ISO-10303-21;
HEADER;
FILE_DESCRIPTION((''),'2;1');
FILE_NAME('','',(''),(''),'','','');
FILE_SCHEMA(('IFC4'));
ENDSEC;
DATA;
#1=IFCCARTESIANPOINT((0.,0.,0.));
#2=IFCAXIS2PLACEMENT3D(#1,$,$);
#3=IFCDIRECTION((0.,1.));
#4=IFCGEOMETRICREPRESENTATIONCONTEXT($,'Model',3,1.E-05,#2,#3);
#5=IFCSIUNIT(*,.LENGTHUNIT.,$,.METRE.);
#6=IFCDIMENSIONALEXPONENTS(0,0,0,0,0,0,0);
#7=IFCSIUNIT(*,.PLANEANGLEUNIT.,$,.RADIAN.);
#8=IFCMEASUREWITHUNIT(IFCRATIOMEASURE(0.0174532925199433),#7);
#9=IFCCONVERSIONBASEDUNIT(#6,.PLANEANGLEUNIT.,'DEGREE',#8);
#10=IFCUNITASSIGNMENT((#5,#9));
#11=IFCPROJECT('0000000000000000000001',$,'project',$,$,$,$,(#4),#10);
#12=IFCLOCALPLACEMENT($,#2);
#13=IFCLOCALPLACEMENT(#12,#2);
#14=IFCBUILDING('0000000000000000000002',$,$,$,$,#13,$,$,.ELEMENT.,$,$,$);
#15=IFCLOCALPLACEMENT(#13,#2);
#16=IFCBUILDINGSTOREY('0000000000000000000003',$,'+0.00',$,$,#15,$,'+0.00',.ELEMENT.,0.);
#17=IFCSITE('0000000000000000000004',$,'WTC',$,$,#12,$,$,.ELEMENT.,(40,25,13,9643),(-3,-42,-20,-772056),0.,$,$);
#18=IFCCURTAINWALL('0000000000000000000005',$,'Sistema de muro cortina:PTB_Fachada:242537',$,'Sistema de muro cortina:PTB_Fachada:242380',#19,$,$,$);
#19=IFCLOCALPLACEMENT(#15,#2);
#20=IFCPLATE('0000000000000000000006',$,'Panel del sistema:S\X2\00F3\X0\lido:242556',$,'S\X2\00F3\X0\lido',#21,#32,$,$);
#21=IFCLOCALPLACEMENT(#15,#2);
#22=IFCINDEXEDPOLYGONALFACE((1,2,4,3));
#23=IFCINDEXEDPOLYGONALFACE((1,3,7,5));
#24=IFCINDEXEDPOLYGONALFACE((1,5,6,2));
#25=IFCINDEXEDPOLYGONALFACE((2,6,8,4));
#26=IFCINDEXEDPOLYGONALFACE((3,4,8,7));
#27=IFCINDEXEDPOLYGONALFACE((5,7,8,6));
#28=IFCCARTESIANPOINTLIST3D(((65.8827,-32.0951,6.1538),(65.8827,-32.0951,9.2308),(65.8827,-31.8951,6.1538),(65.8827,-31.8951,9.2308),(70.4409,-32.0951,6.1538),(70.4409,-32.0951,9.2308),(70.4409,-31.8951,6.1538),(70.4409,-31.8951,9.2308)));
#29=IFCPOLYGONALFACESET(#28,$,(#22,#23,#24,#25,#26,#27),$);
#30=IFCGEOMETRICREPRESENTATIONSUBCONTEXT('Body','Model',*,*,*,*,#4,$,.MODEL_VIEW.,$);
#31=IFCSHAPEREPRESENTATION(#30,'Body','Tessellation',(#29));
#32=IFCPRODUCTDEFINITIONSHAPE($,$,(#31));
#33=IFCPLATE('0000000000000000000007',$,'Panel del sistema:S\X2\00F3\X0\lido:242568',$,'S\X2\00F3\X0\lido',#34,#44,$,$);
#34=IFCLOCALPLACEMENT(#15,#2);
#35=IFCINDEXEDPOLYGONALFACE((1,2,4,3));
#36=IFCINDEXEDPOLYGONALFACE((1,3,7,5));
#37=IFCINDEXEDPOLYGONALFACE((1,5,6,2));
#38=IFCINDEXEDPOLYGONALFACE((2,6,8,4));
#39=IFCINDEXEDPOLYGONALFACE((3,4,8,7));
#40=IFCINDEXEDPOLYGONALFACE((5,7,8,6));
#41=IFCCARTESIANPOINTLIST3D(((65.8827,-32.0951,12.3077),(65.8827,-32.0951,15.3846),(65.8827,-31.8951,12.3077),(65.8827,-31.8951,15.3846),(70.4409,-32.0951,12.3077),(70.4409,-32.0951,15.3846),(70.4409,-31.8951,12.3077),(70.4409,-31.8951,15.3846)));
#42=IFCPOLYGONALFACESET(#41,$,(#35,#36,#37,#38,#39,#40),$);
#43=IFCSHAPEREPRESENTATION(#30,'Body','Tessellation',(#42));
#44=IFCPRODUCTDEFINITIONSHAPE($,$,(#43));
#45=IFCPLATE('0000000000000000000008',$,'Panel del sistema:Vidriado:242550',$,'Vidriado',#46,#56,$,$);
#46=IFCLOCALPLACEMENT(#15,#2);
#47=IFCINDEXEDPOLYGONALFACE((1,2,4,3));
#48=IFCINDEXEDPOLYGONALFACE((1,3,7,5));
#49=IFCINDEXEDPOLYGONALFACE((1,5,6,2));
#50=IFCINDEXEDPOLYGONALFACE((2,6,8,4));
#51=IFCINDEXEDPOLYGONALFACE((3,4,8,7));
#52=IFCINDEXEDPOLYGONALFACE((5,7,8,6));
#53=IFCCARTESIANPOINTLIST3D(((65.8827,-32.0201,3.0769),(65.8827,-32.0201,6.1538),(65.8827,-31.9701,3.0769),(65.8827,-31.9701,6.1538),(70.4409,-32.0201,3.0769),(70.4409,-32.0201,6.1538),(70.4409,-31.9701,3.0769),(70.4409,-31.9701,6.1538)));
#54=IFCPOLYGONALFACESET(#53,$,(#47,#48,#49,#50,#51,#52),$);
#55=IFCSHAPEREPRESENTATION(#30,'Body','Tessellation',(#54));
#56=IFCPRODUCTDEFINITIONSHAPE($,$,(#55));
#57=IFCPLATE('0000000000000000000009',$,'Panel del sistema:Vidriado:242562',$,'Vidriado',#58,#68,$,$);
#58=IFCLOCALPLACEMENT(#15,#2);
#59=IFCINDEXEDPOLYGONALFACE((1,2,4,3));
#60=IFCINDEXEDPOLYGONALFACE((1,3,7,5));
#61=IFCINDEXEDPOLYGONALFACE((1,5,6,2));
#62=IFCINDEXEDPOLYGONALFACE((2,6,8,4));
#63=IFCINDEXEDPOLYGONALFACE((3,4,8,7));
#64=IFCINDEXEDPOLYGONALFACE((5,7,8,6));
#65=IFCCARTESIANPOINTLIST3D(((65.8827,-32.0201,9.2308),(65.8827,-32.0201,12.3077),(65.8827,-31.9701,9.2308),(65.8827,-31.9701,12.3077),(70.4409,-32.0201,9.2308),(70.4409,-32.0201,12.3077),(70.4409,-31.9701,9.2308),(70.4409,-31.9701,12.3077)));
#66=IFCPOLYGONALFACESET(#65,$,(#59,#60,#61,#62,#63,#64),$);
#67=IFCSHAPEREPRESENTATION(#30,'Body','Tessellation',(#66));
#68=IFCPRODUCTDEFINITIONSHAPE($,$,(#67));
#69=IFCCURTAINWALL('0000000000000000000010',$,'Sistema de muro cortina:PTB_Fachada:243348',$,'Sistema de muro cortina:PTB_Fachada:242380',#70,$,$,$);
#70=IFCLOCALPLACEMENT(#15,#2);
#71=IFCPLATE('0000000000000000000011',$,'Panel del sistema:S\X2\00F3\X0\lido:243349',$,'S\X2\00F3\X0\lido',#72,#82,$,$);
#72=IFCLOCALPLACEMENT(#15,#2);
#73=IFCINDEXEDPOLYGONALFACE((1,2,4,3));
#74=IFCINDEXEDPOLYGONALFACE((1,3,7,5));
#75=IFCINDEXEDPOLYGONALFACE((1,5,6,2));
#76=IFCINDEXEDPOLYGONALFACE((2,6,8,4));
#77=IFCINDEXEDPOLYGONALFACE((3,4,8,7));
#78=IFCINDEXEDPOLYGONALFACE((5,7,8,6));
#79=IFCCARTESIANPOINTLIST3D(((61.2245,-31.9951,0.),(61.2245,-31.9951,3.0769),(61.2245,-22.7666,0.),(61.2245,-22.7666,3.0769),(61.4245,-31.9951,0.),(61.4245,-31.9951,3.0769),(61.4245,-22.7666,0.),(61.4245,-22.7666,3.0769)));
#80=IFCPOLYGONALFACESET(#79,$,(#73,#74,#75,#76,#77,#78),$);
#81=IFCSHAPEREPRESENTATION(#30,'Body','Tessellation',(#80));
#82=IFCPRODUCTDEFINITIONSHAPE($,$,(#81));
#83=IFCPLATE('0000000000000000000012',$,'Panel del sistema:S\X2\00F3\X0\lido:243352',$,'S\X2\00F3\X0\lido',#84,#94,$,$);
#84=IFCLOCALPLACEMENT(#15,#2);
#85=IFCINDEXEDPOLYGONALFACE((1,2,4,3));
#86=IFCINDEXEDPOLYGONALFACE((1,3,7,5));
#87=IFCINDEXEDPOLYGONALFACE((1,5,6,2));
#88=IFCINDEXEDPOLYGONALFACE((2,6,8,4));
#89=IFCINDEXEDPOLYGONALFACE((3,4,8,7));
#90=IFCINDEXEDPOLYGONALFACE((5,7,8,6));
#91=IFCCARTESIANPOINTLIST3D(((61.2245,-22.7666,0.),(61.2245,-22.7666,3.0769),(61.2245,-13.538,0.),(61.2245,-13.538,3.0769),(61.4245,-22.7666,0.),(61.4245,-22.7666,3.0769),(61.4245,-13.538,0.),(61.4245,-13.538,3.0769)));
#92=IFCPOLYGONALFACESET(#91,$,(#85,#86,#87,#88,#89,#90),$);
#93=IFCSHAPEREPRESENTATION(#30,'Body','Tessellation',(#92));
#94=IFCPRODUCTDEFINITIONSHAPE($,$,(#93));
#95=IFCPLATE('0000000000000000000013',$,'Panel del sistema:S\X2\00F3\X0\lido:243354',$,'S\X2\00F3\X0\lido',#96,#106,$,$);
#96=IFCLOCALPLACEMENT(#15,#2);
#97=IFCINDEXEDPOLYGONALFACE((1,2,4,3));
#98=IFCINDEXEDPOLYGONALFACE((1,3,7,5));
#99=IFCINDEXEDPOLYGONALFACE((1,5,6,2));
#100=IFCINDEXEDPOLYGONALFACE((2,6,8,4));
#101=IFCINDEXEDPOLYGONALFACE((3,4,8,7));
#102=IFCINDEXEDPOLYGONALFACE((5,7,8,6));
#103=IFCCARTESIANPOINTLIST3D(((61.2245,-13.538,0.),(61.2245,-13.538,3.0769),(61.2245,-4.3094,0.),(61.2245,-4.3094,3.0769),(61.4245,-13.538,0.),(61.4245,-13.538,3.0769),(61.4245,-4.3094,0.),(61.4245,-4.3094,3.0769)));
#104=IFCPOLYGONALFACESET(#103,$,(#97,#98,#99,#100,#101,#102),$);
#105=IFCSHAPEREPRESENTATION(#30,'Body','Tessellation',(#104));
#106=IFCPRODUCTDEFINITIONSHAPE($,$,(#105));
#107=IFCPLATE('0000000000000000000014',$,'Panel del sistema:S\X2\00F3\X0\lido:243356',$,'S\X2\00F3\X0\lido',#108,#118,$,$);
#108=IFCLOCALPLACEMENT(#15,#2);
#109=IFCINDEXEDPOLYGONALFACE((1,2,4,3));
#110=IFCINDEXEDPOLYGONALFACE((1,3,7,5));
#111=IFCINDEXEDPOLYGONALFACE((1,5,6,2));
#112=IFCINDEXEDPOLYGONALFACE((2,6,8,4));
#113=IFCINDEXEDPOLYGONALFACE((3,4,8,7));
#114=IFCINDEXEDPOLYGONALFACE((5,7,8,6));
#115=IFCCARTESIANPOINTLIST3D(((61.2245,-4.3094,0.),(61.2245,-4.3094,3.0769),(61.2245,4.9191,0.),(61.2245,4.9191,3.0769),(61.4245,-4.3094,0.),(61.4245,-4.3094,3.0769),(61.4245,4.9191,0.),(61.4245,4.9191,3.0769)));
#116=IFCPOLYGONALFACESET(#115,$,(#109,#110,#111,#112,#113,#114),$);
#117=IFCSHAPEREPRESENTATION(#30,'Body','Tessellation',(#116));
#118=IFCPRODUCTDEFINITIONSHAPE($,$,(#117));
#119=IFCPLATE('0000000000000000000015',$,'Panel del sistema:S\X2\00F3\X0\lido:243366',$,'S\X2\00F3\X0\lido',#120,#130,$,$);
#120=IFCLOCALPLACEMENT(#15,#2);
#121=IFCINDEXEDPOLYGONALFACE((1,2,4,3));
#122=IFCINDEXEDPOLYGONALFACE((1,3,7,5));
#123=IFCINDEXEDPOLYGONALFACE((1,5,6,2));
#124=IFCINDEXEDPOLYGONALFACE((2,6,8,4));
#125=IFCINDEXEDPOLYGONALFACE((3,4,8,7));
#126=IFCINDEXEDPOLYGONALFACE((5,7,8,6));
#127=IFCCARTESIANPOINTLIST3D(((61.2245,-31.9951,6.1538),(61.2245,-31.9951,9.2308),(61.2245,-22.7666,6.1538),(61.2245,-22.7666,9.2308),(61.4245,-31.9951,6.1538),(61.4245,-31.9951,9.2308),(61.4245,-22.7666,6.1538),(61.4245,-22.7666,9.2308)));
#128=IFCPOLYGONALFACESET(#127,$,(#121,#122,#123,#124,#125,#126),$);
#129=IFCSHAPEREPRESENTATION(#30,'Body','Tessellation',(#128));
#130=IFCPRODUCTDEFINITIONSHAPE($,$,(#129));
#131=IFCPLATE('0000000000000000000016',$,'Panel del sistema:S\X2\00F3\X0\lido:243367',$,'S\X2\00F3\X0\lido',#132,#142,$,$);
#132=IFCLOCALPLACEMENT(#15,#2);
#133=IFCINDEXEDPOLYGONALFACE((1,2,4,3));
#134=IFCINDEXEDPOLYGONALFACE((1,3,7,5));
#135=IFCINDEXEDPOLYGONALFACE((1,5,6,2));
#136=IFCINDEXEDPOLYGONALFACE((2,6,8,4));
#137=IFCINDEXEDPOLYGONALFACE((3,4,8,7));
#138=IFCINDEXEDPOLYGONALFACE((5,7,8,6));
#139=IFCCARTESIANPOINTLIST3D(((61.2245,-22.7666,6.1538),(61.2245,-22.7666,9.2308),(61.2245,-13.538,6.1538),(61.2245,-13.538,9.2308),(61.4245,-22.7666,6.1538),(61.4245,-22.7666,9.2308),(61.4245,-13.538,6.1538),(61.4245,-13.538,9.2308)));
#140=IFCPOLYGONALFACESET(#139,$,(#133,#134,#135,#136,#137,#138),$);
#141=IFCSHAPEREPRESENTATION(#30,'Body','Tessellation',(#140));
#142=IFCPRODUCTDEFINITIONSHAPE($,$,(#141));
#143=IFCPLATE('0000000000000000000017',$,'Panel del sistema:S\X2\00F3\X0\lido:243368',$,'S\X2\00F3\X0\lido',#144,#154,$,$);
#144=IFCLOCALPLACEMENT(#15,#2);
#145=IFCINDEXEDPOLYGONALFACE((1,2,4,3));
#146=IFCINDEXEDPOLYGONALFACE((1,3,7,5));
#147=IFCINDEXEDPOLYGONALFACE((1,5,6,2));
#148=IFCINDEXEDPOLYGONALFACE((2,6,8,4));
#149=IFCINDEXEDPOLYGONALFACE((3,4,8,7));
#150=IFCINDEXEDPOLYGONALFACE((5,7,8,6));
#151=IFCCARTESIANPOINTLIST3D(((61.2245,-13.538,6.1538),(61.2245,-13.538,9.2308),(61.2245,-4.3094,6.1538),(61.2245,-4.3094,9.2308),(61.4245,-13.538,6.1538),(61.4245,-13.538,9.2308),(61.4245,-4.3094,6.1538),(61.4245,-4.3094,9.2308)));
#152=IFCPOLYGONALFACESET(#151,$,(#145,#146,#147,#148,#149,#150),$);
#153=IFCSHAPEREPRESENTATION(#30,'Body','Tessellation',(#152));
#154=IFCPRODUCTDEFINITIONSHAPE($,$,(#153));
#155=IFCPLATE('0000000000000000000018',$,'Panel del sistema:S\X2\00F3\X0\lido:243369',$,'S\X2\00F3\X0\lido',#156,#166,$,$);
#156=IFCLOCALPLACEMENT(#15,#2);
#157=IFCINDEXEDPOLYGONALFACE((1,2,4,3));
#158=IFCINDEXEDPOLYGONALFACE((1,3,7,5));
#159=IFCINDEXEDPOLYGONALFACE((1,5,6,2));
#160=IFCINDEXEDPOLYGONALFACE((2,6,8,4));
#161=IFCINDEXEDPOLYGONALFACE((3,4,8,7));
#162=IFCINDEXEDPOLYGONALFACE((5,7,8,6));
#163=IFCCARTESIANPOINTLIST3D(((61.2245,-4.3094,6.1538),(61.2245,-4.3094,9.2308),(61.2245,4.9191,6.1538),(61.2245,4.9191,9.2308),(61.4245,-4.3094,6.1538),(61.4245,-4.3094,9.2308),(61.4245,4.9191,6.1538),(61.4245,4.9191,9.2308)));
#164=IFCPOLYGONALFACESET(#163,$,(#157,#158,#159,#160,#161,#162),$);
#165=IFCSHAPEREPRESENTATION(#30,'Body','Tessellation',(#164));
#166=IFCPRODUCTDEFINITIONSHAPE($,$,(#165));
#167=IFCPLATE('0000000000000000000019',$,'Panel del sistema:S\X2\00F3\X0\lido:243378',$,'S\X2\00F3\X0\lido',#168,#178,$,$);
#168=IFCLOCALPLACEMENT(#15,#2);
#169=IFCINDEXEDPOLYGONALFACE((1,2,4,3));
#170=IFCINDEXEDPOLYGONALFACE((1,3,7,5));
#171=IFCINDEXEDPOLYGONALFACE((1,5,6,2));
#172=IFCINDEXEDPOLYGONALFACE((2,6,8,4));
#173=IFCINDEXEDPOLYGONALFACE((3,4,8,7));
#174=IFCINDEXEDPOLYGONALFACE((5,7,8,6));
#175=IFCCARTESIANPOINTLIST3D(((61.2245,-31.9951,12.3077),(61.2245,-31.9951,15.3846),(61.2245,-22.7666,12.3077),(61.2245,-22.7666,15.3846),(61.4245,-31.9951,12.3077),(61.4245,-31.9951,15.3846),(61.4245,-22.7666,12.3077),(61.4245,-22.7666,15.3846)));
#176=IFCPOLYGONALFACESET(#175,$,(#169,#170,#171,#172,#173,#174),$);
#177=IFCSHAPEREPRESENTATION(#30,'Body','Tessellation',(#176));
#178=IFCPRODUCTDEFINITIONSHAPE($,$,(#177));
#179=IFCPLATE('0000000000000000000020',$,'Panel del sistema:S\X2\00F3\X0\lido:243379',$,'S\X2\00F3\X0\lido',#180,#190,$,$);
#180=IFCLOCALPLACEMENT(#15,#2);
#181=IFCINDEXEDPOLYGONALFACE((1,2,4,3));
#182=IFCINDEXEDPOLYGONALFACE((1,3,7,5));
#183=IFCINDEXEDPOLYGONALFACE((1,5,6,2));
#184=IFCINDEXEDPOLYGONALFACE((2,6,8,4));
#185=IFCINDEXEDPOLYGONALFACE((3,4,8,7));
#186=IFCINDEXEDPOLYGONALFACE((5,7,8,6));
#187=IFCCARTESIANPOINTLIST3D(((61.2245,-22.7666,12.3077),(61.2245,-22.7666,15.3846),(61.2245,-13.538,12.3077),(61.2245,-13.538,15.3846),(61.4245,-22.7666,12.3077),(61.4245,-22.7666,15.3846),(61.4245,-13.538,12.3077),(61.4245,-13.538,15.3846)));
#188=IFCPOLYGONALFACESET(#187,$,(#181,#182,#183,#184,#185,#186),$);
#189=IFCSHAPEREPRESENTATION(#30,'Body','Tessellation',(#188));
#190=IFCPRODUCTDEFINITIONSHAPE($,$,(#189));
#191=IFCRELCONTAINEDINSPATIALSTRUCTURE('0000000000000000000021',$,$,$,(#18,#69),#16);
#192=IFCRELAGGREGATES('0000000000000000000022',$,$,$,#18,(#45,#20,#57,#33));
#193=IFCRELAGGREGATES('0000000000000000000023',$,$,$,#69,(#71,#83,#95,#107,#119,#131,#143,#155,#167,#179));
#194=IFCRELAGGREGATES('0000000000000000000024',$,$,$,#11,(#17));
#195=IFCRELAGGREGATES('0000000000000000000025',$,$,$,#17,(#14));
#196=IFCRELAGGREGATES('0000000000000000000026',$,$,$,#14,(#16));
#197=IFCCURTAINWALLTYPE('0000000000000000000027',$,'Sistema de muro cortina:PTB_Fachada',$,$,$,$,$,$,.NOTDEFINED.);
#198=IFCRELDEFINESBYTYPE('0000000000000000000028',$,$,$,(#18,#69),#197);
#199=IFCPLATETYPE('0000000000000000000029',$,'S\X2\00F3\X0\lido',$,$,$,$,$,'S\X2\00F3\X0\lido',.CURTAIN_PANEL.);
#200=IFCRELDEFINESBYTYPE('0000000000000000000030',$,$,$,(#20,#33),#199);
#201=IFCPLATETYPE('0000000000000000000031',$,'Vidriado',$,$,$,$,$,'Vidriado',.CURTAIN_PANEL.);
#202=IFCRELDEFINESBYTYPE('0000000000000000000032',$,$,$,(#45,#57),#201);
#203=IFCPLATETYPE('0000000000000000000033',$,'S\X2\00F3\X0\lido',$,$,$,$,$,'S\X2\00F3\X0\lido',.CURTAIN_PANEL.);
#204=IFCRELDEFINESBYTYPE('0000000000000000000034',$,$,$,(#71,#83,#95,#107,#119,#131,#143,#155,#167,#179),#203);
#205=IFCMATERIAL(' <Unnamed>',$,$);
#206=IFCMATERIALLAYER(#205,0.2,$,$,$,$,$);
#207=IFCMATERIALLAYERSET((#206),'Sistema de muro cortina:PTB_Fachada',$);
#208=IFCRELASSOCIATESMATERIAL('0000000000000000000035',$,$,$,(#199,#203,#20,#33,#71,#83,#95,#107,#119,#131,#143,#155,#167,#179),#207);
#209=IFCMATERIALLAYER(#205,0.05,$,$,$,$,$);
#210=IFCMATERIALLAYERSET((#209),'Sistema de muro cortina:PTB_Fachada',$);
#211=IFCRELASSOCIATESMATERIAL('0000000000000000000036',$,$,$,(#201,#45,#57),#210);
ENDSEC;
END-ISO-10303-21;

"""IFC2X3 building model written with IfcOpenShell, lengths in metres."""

from ifc_helpers import new_model, entity, si_unit, converted_unit, direction, frame, frame_2d, origin, origin_2d_with_axis, place, context, subcontext, project, spatial, rectangle, extrude, source, transform, mapped, material, layer, layer_set, layer_usage, type_object, type_shapes, element, aggregate, save


model = new_model("IFC2X3")

# Units and contexts
model_context = context("Model", 3, precision=1e-05, world=origin(), true_north=direction((0.0, 1.0)))
body_context = subcontext(model_context, "Body", "Model", "MODEL_VIEW")
ifc_project = project(units=[si_unit("LENGTHUNIT", "METRE"), converted_unit("PLANEANGLEUNIT", "DEGREE", entity("IfcRatioMeasure", 0.0174532925199433), si_unit("PLANEANGLEUNIT", "RADIAN"), dimensions=[0, 0, 0, 0, 0, 0, 0])], contexts=[model_context])

# Site, building, storey
site_placement = place(None, origin())
site = spatial("IfcSite", under=ifc_project, at=site_placement, Name="WTC", CompositionType="ELEMENT", RefLatitude=(40, 25, 13, 9643), RefLongitude=(-3, -42, -20, -772056), RefElevation=0.0)
building_placement = place(site_placement, origin())
building = spatial("IfcBuilding", under=site, at=building_placement, CompositionType="ELEMENT")
storey_placement = place(building_placement, origin())
storey = spatial("IfcBuildingStorey", under=building, at=storey_placement, Name="+0.00", LongName="+0.00", CompositionType="ELEMENT", Elevation=0.0)

# Curtain walls, plates
curtain_wall_type = type_object("IfcCurtainWallType", Name="Sistema de muro cortina:PTB_Fachada", PredefinedType="NOTDEFINED")
curtain_wall_1_placement = place(storey_placement, origin())
curtain_wall_1 = element("IfcCurtainWall", 1, at=curtain_wall_1_placement, inside=storey, type_object=curtain_wall_type, Name="Sistema de muro cortina:PTB_Fachada:242537", ObjectType="Sistema de muro cortina:PTB_Fachada:242380")
ifc_material_1 = material(Name=" <Unnamed>")
ifc_layer_1 = layer(ifc_material_1, 0.2)
ifc_layer_set_1 = layer_set([ifc_layer_1], Name="Sistema de muro cortina:PTB_Fachada")
ifc_layer_usage_1 = layer_usage(ifc_layer_set_1, "AXIS3", "POSITIVE", 0.0)
plate_type_1 = type_object("IfcPlateType", Name="Sólido", ElementType="Sólido", PredefinedType="CURTAIN_PANEL", material=ifc_layer_set_1)
shared_shape_1 = source(origin(), body_context, "Body", "SweptSolid", [
    extrude(rectangle(XDim=0.2, YDim=4.5582, at=origin_2d_with_axis()), frame((0.0, 0.0, 0.0), z_axis=(0.0, 0.0, 1.0), x_axis=(0.0, 1.0, 0.0)), (0.0, 0.0, 1.0), 3.0769),
])
type_shapes(plate_type_1, [shared_shape_1])
plate_1_placement = place(curtain_wall_1_placement, frame((68.1618, -31.9951, 6.1538), z_axis=(0.0, 0.0, 1.0), x_axis=(-1.0, 0.0, 0.0)))
plate_1 = element("IfcPlate", 2, at=plate_1_placement, type_object=plate_type_1, material=ifc_layer_usage_1, Name="Panel del sistema:Sólido:242556", ObjectType="Sólido", context=body_context, shape_type="MappedRepresentation", body=[
    mapped(shared_shape_1, transform((0.0, 0.0, 0.0), scale=1.0)),
])
ifc_layer_usage_2 = layer_usage(ifc_layer_set_1, "AXIS3", "POSITIVE", 0.0)
plate_2_placement = place(curtain_wall_1_placement, frame((68.1618, -31.9951, 12.3077), z_axis=(0.0, 0.0, 1.0), x_axis=(-1.0, 0.0, 0.0)))
plate_2 = element("IfcPlate", 3, at=plate_2_placement, type_object=plate_type_1, material=ifc_layer_usage_2, Name="Panel del sistema:Sólido:242568", ObjectType="Sólido", context=body_context, shape_type="MappedRepresentation", body=[
    mapped(shared_shape_1, transform((0.0, 0.0, 0.0), scale=1.0)),
])
ifc_layer_2 = layer(ifc_material_1, 0.05)
ifc_layer_set_2 = layer_set([ifc_layer_2], Name="Sistema de muro cortina:PTB_Fachada")
ifc_layer_usage_3 = layer_usage(ifc_layer_set_2, "AXIS3", "POSITIVE", 0.0)
plate_type_2 = type_object("IfcPlateType", Name="Vidriado", ElementType="Vidriado", PredefinedType="CURTAIN_PANEL", material=ifc_layer_set_2)
shared_shape_2 = source(origin(), body_context, "Body", "SweptSolid", [
    extrude(rectangle(XDim=0.05, YDim=4.5582, at=origin_2d_with_axis()), frame((0.0, 0.0, 0.0), z_axis=(0.0, 0.0, 1.0), x_axis=(0.0, 1.0, 0.0)), (0.0, 0.0, 1.0), 3.0769),
])
type_shapes(plate_type_2, [shared_shape_2])
plate_3_placement = place(curtain_wall_1_placement, frame((68.1618, -31.9951, 3.0769), z_axis=(0.0, 0.0, 1.0), x_axis=(-1.0, 0.0, 0.0)))
plate_3 = element("IfcPlate", 4, at=plate_3_placement, type_object=plate_type_2, material=ifc_layer_usage_3, Name="Panel del sistema:Vidriado:242550", ObjectType="Vidriado", context=body_context, shape_type="MappedRepresentation", body=[
    mapped(shared_shape_2, transform((0.0, 0.0, 0.0), scale=1.0)),
])
ifc_layer_usage_4 = layer_usage(ifc_layer_set_2, "AXIS3", "POSITIVE", 0.0)
plate_4_placement = place(curtain_wall_1_placement, frame((68.1618, -31.9951, 9.2308), z_axis=(0.0, 0.0, 1.0), x_axis=(-1.0, 0.0, 0.0)))
plate_4 = element("IfcPlate", 5, at=plate_4_placement, type_object=plate_type_2, material=ifc_layer_usage_4, Name="Panel del sistema:Vidriado:242562", ObjectType="Vidriado", context=body_context, shape_type="MappedRepresentation", body=[
    mapped(shared_shape_2, transform((0.0, 0.0, 0.0), scale=1.0)),
])
aggregate(curtain_wall_1, [plate_3, plate_1, plate_4, plate_2])
curtain_wall_2_placement = place(storey_placement, origin())
curtain_wall_2 = element("IfcCurtainWall", 6, at=curtain_wall_2_placement, inside=storey, type_object=curtain_wall_type, Name="Sistema de muro cortina:PTB_Fachada:243348", ObjectType="Sistema de muro cortina:PTB_Fachada:242380")
ifc_layer_usage_5 = layer_usage(ifc_layer_set_1, "AXIS3", "POSITIVE", 0.0)
plate_type_3 = type_object("IfcPlateType", Name="Sólido", ElementType="Sólido", PredefinedType="CURTAIN_PANEL", material=ifc_layer_set_1)
shared_shape_3 = source(origin(), body_context, "Body", "SweptSolid", [
    extrude(rectangle(XDim=0.2, YDim=9.2286, at=frame_2d((0.0, 0.0), x_axis=(1.0, 0.0))), frame((0.0, 0.0, 0.0), z_axis=(0.0, 0.0, 1.0), x_axis=(0.0, 1.0, 0.0)), (0.0, 0.0, 1.0), 3.0769),
])
type_shapes(plate_type_3, [shared_shape_3])
plate_5_placement = place(curtain_wall_2_placement, frame((61.3245, -27.3809, 0.0), z_axis=(0.0, 0.0, 1.0), x_axis=(0.0, 1.0, 0.0)))
plate_5 = element("IfcPlate", 7, at=plate_5_placement, type_object=plate_type_3, material=ifc_layer_usage_5, Name="Panel del sistema:Sólido:243349", ObjectType="Sólido", context=body_context, shape_type="MappedRepresentation", body=[
    mapped(shared_shape_3, transform((0.0, 0.0, 0.0), scale=1.0)),
])
ifc_layer_usage_6 = layer_usage(ifc_layer_set_1, "AXIS3", "POSITIVE", 0.0)
plate_6_placement = place(curtain_wall_2_placement, frame((61.3245, -18.1523, 0.0), z_axis=(0.0, 0.0, 1.0), x_axis=(0.0, 1.0, 0.0)))
plate_6 = element("IfcPlate", 8, at=plate_6_placement, type_object=plate_type_3, material=ifc_layer_usage_6, Name="Panel del sistema:Sólido:243352", ObjectType="Sólido", context=body_context, shape_type="MappedRepresentation", body=[
    mapped(shared_shape_3, transform((0.0, 0.0, 0.0), scale=1.0)),
])
ifc_layer_usage_7 = layer_usage(ifc_layer_set_1, "AXIS3", "POSITIVE", 0.0)
plate_7_placement = place(curtain_wall_2_placement, frame((61.3245, -8.9237, 0.0), z_axis=(0.0, 0.0, 1.0), x_axis=(0.0, 1.0, 0.0)))
plate_7 = element("IfcPlate", 9, at=plate_7_placement, type_object=plate_type_3, material=ifc_layer_usage_7, Name="Panel del sistema:Sólido:243354", ObjectType="Sólido", context=body_context, shape_type="MappedRepresentation", body=[
    mapped(shared_shape_3, transform((0.0, 0.0, 0.0), scale=1.0)),
])
ifc_layer_usage_8 = layer_usage(ifc_layer_set_1, "AXIS3", "POSITIVE", 0.0)
plate_8_placement = place(curtain_wall_2_placement, frame((61.3245, 0.3049, 0.0), z_axis=(0.0, 0.0, 1.0), x_axis=(0.0, 1.0, 0.0)))
plate_8 = element("IfcPlate", 10, at=plate_8_placement, type_object=plate_type_3, material=ifc_layer_usage_8, Name="Panel del sistema:Sólido:243356", ObjectType="Sólido", context=body_context, shape_type="MappedRepresentation", body=[
    mapped(shared_shape_3, transform((0.0, 0.0, 0.0), scale=1.0)),
])
ifc_layer_usage_9 = layer_usage(ifc_layer_set_1, "AXIS3", "POSITIVE", 0.0)
plate_9_placement = place(curtain_wall_2_placement, frame((61.3245, -27.3809, 6.1538), z_axis=(0.0, 0.0, 1.0), x_axis=(0.0, 1.0, 0.0)))
plate_9 = element("IfcPlate", 11, at=plate_9_placement, type_object=plate_type_3, material=ifc_layer_usage_9, Name="Panel del sistema:Sólido:243366", ObjectType="Sólido", context=body_context, shape_type="MappedRepresentation", body=[
    mapped(shared_shape_3, transform((0.0, 0.0, 0.0), scale=1.0)),
])
ifc_layer_usage_10 = layer_usage(ifc_layer_set_1, "AXIS3", "POSITIVE", 0.0)
plate_10_placement = place(curtain_wall_2_placement, frame((61.3245, -18.1523, 6.1538), z_axis=(0.0, 0.0, 1.0), x_axis=(0.0, 1.0, 0.0)))
plate_10 = element("IfcPlate", 12, at=plate_10_placement, type_object=plate_type_3, material=ifc_layer_usage_10, Name="Panel del sistema:Sólido:243367", ObjectType="Sólido", context=body_context, shape_type="MappedRepresentation", body=[
    mapped(shared_shape_3, transform((0.0, 0.0, 0.0), scale=1.0)),
])
ifc_layer_usage_11 = layer_usage(ifc_layer_set_1, "AXIS3", "POSITIVE", 0.0)
plate_11_placement = place(curtain_wall_2_placement, frame((61.3245, -8.9237, 6.1538), z_axis=(0.0, 0.0, 1.0), x_axis=(0.0, 1.0, 0.0)))
plate_11 = element("IfcPlate", 13, at=plate_11_placement, type_object=plate_type_3, material=ifc_layer_usage_11, Name="Panel del sistema:Sólido:243368", ObjectType="Sólido", context=body_context, shape_type="MappedRepresentation", body=[
    mapped(shared_shape_3, transform((0.0, 0.0, 0.0), scale=1.0)),
])
ifc_layer_usage_12 = layer_usage(ifc_layer_set_1, "AXIS3", "POSITIVE", 0.0)
plate_12_placement = place(curtain_wall_2_placement, frame((61.3245, 0.3049, 6.1538), z_axis=(0.0, 0.0, 1.0), x_axis=(0.0, 1.0, 0.0)))
plate_12 = element("IfcPlate", 14, at=plate_12_placement, type_object=plate_type_3, material=ifc_layer_usage_12, Name="Panel del sistema:Sólido:243369", ObjectType="Sólido", context=body_context, shape_type="MappedRepresentation", body=[
    mapped(shared_shape_3, transform((0.0, 0.0, 0.0), scale=1.0)),
])
ifc_layer_usage_13 = layer_usage(ifc_layer_set_1, "AXIS3", "POSITIVE", 0.0)
plate_13_placement = place(curtain_wall_2_placement, frame((61.3245, -27.3809, 12.3077), z_axis=(0.0, 0.0, 1.0), x_axis=(0.0, 1.0, 0.0)))
plate_13 = element("IfcPlate", 15, at=plate_13_placement, type_object=plate_type_3, material=ifc_layer_usage_13, Name="Panel del sistema:Sólido:243378", ObjectType="Sólido", context=body_context, shape_type="MappedRepresentation", body=[
    mapped(shared_shape_3, transform((0.0, 0.0, 0.0), scale=1.0)),
])
ifc_layer_usage_14 = layer_usage(ifc_layer_set_1, "AXIS3", "POSITIVE", 0.0)
plate_14_placement = place(curtain_wall_2_placement, frame((61.3245, -18.1523, 12.3077), z_axis=(0.0, 0.0, 1.0), x_axis=(0.0, 1.0, 0.0)))
plate_14 = element("IfcPlate", 16, at=plate_14_placement, type_object=plate_type_3, material=ifc_layer_usage_14, Name="Panel del sistema:Sólido:243379", ObjectType="Sólido", context=body_context, shape_type="MappedRepresentation", body=[
    mapped(shared_shape_3, transform((0.0, 0.0, 0.0), scale=1.0)),
])
aggregate(curtain_wall_2, [plate_5, plate_6, plate_7, plate_8, plate_9, plate_10, plate_11, plate_12, plate_13, plate_14])

save(model, "model.ifc")
